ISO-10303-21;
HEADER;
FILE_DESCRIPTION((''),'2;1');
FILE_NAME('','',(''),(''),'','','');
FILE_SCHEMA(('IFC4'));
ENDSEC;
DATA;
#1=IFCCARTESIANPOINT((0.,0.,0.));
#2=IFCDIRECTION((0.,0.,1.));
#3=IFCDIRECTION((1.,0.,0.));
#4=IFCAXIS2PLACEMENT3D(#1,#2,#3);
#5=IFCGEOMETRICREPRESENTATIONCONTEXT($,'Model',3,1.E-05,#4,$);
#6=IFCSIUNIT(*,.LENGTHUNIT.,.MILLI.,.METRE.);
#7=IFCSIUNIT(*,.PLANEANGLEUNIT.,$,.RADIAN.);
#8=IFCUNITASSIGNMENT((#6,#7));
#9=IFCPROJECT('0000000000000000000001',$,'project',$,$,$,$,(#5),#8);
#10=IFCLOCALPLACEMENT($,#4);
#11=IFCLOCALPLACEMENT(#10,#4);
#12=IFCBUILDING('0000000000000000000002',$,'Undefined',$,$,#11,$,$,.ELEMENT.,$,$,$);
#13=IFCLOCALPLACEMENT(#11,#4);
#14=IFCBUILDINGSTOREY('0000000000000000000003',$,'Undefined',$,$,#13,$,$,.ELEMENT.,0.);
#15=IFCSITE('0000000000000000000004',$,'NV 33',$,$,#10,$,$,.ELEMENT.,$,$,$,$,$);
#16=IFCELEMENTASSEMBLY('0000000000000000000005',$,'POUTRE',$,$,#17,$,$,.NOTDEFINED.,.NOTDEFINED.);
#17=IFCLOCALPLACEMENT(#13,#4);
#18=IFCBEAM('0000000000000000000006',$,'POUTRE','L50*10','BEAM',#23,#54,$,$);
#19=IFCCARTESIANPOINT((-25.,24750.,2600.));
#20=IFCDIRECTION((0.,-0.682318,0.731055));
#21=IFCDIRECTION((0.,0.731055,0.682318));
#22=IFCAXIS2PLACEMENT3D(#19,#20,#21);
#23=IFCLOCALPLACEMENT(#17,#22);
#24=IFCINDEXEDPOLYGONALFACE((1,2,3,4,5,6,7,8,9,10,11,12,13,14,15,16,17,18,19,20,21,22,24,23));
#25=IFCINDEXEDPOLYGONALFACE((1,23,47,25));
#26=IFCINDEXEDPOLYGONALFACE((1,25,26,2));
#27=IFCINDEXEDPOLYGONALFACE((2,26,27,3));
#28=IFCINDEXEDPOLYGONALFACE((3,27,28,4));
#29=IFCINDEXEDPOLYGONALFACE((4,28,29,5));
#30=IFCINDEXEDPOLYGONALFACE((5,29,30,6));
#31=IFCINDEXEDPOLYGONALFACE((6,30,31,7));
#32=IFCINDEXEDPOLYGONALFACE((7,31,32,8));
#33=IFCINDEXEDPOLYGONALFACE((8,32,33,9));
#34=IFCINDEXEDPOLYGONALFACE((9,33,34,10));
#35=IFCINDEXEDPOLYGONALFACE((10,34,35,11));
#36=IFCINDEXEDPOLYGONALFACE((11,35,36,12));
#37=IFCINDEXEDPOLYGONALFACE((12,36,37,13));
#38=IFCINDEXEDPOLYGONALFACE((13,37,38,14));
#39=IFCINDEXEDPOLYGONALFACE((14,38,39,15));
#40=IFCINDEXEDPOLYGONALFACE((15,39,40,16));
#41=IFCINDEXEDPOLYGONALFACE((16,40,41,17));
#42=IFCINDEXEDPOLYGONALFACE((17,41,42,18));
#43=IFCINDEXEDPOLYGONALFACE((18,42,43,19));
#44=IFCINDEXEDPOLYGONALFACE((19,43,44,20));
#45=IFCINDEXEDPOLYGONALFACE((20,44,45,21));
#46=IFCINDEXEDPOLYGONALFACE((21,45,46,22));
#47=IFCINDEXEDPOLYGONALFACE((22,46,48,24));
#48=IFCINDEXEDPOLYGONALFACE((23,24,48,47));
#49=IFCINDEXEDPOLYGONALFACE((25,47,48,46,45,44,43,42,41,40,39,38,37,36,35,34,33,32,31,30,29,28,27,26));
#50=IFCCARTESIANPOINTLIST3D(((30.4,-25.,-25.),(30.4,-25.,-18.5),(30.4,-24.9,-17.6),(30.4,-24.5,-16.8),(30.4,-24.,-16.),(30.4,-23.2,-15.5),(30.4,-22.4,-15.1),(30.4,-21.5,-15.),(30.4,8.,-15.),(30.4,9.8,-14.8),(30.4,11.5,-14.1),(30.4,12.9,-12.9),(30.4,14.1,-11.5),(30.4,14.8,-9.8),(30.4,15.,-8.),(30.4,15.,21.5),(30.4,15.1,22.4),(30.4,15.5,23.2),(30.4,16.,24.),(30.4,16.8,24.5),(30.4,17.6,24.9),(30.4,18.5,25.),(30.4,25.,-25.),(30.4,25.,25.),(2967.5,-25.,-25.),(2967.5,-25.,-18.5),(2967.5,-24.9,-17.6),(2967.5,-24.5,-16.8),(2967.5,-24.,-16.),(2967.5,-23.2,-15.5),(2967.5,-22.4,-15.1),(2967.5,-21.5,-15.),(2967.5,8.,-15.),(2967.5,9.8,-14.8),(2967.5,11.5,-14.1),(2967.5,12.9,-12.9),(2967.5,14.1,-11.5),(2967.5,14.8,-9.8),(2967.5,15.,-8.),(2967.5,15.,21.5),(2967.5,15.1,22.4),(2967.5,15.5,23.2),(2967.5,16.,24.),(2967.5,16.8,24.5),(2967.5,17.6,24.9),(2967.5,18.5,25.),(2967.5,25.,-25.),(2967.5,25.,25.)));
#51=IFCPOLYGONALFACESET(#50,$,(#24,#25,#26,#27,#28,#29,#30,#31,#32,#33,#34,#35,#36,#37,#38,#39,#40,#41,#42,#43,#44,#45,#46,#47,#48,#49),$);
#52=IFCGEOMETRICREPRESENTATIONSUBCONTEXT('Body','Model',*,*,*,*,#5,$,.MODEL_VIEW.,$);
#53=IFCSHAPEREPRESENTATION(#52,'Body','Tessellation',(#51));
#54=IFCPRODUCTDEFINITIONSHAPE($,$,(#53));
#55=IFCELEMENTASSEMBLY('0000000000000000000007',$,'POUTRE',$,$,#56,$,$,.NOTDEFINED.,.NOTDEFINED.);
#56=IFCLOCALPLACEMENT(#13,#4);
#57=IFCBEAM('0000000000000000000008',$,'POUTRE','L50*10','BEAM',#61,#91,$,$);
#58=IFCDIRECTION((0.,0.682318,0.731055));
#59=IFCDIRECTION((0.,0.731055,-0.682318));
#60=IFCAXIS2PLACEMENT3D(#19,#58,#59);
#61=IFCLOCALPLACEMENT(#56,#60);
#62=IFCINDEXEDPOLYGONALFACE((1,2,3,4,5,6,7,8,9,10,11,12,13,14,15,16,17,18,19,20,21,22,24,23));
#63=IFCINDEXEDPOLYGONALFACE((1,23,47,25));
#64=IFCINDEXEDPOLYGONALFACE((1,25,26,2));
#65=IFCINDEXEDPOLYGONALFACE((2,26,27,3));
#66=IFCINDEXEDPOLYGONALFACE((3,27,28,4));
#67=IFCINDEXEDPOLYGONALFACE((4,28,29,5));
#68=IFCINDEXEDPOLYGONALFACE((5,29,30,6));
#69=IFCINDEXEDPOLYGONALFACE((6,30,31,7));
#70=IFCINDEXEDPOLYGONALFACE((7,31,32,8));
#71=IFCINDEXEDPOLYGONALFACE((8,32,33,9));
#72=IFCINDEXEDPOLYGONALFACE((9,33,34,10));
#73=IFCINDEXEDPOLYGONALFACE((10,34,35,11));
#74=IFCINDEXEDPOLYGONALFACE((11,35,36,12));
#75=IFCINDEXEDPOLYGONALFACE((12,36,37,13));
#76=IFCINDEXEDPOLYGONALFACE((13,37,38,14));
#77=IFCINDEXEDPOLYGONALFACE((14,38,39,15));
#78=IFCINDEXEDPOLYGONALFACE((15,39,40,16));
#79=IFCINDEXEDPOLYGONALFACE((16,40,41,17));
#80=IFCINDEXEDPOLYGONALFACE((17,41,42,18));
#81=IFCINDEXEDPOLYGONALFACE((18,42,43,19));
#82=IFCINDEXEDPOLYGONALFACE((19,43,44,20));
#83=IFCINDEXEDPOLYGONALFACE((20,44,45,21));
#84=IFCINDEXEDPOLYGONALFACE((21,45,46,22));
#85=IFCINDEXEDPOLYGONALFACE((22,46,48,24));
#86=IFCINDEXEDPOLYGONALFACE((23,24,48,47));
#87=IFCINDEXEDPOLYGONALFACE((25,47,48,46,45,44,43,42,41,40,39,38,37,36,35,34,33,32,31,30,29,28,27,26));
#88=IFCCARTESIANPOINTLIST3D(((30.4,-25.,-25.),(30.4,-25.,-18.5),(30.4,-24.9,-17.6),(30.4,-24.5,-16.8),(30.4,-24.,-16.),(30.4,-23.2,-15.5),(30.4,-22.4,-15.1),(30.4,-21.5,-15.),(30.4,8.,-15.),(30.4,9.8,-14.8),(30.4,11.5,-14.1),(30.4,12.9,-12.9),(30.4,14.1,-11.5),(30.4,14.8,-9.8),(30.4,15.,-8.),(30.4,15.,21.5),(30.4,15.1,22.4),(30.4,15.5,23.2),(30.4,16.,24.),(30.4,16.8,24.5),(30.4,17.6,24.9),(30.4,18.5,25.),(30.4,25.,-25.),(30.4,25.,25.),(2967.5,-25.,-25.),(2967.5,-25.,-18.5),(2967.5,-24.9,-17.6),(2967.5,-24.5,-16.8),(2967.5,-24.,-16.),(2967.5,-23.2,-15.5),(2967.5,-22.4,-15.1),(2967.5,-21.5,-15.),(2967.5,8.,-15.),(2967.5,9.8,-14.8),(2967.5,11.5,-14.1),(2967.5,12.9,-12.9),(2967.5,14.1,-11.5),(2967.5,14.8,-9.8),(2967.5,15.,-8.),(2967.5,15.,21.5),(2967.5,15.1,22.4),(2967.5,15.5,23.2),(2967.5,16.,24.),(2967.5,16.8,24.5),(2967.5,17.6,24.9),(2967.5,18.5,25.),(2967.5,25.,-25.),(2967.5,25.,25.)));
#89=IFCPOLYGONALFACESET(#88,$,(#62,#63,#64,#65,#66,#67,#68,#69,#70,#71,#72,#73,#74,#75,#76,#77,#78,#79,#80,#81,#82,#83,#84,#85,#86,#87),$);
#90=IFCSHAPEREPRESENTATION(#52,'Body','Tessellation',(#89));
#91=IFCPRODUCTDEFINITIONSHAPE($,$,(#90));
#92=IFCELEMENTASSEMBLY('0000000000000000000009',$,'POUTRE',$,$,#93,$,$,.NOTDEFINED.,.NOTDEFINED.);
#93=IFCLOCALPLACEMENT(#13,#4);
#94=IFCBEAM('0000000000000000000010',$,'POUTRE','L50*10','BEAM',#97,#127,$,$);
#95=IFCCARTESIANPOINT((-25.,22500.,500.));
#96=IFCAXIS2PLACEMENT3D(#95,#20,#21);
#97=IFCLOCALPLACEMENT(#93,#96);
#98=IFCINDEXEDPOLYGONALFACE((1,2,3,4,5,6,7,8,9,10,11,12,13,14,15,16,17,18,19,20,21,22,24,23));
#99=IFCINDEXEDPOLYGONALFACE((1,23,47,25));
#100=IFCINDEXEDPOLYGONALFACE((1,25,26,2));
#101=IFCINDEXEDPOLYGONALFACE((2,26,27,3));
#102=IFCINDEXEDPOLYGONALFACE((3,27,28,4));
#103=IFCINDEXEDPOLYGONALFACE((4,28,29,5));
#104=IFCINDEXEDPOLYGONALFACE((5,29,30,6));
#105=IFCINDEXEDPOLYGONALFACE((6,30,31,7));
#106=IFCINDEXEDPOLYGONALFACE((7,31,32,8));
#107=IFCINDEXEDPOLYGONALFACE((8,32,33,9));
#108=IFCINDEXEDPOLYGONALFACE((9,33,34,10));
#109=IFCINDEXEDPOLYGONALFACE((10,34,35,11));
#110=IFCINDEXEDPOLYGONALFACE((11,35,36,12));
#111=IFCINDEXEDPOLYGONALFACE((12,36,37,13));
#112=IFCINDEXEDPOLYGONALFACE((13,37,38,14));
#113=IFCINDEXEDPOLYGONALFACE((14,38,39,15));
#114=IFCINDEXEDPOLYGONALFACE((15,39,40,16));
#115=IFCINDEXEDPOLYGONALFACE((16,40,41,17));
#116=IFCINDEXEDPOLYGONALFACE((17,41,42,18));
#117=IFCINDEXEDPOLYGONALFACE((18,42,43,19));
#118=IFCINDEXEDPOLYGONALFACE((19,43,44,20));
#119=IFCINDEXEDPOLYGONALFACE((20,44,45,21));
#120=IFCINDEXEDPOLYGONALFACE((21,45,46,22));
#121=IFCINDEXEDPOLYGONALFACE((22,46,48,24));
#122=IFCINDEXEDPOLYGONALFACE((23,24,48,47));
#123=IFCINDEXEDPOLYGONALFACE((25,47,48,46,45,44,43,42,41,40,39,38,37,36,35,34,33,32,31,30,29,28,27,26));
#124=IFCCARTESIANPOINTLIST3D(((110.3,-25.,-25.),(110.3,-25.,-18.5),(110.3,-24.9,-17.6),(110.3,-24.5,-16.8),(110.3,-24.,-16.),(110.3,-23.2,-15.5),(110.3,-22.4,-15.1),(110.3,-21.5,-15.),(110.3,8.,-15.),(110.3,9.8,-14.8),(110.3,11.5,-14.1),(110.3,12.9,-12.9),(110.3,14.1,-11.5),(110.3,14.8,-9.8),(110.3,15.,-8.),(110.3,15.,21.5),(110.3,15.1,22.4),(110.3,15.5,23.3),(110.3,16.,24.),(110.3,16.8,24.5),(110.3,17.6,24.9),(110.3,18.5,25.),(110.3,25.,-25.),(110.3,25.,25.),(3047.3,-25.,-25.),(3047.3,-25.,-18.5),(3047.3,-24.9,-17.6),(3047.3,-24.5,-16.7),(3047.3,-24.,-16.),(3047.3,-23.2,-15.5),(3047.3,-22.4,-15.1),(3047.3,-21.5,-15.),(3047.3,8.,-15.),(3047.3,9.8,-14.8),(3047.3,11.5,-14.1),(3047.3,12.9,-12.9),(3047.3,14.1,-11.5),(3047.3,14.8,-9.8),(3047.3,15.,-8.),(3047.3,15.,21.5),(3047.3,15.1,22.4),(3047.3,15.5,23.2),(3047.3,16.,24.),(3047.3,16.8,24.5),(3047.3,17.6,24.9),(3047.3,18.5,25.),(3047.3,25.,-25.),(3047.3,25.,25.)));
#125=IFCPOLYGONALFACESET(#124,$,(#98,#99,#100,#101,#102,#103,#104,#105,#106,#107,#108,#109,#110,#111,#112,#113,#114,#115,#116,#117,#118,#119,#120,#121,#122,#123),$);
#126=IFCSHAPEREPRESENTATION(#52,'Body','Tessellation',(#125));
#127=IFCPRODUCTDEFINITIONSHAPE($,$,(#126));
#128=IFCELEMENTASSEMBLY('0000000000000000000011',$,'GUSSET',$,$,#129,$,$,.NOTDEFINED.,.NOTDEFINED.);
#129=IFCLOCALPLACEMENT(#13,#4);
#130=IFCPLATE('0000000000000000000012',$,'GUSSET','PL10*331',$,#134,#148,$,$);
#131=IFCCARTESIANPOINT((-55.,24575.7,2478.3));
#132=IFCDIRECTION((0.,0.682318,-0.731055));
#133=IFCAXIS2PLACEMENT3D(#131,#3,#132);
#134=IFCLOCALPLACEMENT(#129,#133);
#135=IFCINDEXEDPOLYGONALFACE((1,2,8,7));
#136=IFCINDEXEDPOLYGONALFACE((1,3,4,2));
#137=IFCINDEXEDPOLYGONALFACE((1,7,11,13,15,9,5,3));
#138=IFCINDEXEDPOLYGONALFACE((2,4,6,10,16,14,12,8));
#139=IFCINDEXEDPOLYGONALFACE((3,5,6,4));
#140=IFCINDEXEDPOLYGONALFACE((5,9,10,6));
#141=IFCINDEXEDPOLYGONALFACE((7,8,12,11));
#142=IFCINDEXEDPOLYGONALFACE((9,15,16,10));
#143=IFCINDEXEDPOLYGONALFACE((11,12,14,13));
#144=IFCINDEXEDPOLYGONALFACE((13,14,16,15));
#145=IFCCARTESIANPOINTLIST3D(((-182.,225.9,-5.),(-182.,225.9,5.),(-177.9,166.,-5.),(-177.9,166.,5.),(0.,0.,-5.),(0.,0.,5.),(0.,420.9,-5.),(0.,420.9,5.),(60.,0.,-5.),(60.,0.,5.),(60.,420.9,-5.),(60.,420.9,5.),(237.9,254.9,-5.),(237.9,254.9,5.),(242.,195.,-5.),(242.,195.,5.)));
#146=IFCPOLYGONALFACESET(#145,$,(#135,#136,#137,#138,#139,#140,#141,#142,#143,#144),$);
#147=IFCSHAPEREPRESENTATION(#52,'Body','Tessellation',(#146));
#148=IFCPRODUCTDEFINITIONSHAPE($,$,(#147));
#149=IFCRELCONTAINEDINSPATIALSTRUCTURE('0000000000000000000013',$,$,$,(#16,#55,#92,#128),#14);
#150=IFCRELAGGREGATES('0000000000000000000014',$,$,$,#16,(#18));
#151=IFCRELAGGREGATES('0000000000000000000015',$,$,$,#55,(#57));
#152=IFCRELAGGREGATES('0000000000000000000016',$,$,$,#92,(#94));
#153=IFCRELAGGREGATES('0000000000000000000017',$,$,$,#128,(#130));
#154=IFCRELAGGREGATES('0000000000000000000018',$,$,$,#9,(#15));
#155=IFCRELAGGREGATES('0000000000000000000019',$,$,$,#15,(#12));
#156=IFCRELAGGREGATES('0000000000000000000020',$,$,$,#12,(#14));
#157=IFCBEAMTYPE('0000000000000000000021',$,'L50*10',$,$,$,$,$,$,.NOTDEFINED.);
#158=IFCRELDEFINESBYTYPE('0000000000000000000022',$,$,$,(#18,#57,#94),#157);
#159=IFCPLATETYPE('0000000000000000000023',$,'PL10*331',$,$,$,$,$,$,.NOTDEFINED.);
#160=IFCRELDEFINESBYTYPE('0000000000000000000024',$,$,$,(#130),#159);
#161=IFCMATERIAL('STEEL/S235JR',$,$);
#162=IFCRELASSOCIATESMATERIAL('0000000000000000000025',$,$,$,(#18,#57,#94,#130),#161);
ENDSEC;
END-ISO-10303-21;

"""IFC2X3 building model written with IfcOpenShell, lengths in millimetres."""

from ifc_helpers import new_model, si_unit, frame, origin_with_axes, origin_2d_with_axis, place, context, subcontext, project, spatial, polyline, l_section, outline, extrude, clip, halfspace, material, type_object, element, aggregate, save


model = new_model("IFC2X3")

# Units and contexts
model_context = context("Model", 3, precision=1e-05, world=origin_with_axes())
body_context = subcontext(model_context, "Body", "Model", "MODEL_VIEW")
ifc_project = project(units=[si_unit("LENGTHUNIT", "METRE", prefix="MILLI"), si_unit("PLANEANGLEUNIT", "RADIAN")], contexts=[model_context])

# Site, building, storey
site_placement = place(None, origin_with_axes())
site = spatial("IfcSite", under=ifc_project, at=site_placement, Name="NV 33", CompositionType="ELEMENT")
building_placement = place(site_placement, origin_with_axes())
building = spatial("IfcBuilding", under=site, at=building_placement, Name="Undefined", CompositionType="ELEMENT")
storey_placement = place(building_placement, origin_with_axes())
storey = spatial("IfcBuildingStorey", under=building, at=storey_placement, Name="Undefined", CompositionType="ELEMENT", Elevation=0.0)

# Element assemblies, beams
assembly_1_placement = place(storey_placement, origin_with_axes())
assembly_1 = element("IfcElementAssembly", 1, at=assembly_1_placement, inside=storey, Name="POUTRE", AssemblyPlace="NOTDEFINED", PredefinedType="NOTDEFINED")
ifc_material_1 = material(Name="STEEL/S235JR")
beam_type_1 = type_object("IfcBeamType", Name="L50*10", PredefinedType="NOTDEFINED")
beam_1_placement = place(assembly_1_placement, frame((-25.0, 24750.0, 2600.0), z_axis=(0.0, -0.682318, 0.731055), x_axis=(0.0, 0.731055, 0.682318)))
beam_1 = element("IfcBeam", 2, at=beam_1_placement, type_object=beam_type_1, material=ifc_material_1, Name="POUTRE", Description="L50*10", ObjectType="BEAM", context=body_context, shape_type="Clipping", body=[
    clip(clip(extrude(l_section(Depth=50.0, Width=50.0, Thickness=10.0, FilletRadius=7.0, EdgeRadius=3.5, at=origin_2d_with_axis()), frame((3077.7, 0.0, 0.0), z_axis=(-1.0, 0.0, 0.0), x_axis=(0.0, -1.0, 0.0)), (0.0, 0.0, 1.0), 3097.7), halfspace(frame((2967.5, 31.0, 0.0), z_axis=(-1.0, 0.0, 0.0), x_axis=(0.0, 0.0, 1.0)), True)), halfspace(frame((30.4, 0.0, 25.0), z_axis=(1.0, 0.0, 0.0), x_axis=(0.0, 1.0, 0.0)), True)),
])
assembly_2_placement = place(storey_placement, origin_with_axes())
assembly_2 = element("IfcElementAssembly", 3, at=assembly_2_placement, inside=storey, Name="POUTRE", AssemblyPlace="NOTDEFINED", PredefinedType="NOTDEFINED")
beam_2_placement = place(assembly_2_placement, frame((-25.0, 24750.0, 2600.0), z_axis=(0.0, 0.682318, 0.731055), x_axis=(0.0, 0.731055, -0.682318)))
beam_2 = element("IfcBeam", 4, at=beam_2_placement, type_object=beam_type_1, material=ifc_material_1, Name="POUTRE", Description="L50*10", ObjectType="BEAM", context=body_context, shape_type="Clipping", body=[
    clip(clip(extrude(l_section(Depth=50.0, Width=50.0, Thickness=10.0, FilletRadius=7.0, EdgeRadius=3.5, at=origin_2d_with_axis()), frame((3077.7, 0.0, 0.0), z_axis=(-1.0, 0.0, 0.0), x_axis=(0.0, -1.0, 0.0)), (0.0, 0.0, 1.0), 3097.7), halfspace(frame((2967.5, 31.0, 0.0), z_axis=(-1.0, 0.0, 0.0), x_axis=(0.0, 0.0, 1.0)), True)), halfspace(frame((30.4, 0.0, 25.0), z_axis=(1.0, 0.0, 0.0), x_axis=(0.0, 1.0, 0.0)), True)),
])
assembly_3_placement = place(storey_placement, origin_with_axes())
assembly_3 = element("IfcElementAssembly", 5, at=assembly_3_placement, inside=storey, Name="POUTRE", AssemblyPlace="NOTDEFINED", PredefinedType="NOTDEFINED")
beam_3_placement = place(assembly_3_placement, frame((-25.0, 22500.0, 500.0), z_axis=(0.0, -0.682318, 0.731055), x_axis=(0.0, 0.731055, 0.682318)))
beam_3 = element("IfcBeam", 6, at=beam_3_placement, type_object=beam_type_1, material=ifc_material_1, Name="POUTRE", Description="L50*10", ObjectType="BEAM", context=body_context, shape_type="Clipping", body=[
    clip(clip(extrude(l_section(Depth=50.0, Width=50.0, Thickness=10.0, FilletRadius=7.0, EdgeRadius=3.5, at=origin_2d_with_axis()), frame((3097.7, 0.0, 0.0), z_axis=(-1.0, 0.0, 0.0), x_axis=(0.0, -1.0, 0.0)), (0.0, 0.0, 1.0), 3097.7), halfspace(frame((3047.3, 0.0, -25.0), z_axis=(-1.0, 0.0, 0.0), x_axis=(0.0, 1.0, 0.0)), True)), halfspace(frame((110.3, 31.0, 0.0), z_axis=(1.0, 0.0, 0.0), x_axis=(0.0, 0.0, -1.0)), True)),
])

# Element assembly, plate
assembly_4_placement = place(storey_placement, origin_with_axes())
assembly_4 = element("IfcElementAssembly", 7, at=assembly_4_placement, inside=storey, Name="GUSSET", AssemblyPlace="NOTDEFINED", PredefinedType="NOTDEFINED")
plate_type_1 = type_object("IfcPlateType", Name="PL10*331", PredefinedType="NOTDEFINED")
plate_1_placement = place(assembly_4_placement, frame((-55.0, 24575.7, 2478.3), z_axis=(1.0, 0.0, 0.0), x_axis=(0.0, 0.682318, -0.731055)))
plate_1 = element("IfcPlate", 8, at=plate_1_placement, type_object=plate_type_1, material=ifc_material_1, Name="GUSSET", Description="PL10*331", context=body_context, shape_type="SweptSolid", body=[
    extrude(outline(polyline([(0.0, 0.0), (60.0, 0.0), (242.0, 195.0), (237.9, 254.9), (60.0, 420.9), (0.0, 420.9), (-182.0, 225.9), (-177.9, 166.0), (0.0, 0.0)])), frame((0.0, 0.0, -5.0), z_axis=(0.0, 0.0, 1.0), x_axis=(1.0, 0.0, 0.0)), (0.0, 0.0, 1.0), 10.0),
])

aggregate(assembly_1, [beam_1])
aggregate(assembly_2, [beam_2])
aggregate(assembly_3, [beam_3])

aggregate(assembly_4, [plate_1])

save(model, "model.ifc")
